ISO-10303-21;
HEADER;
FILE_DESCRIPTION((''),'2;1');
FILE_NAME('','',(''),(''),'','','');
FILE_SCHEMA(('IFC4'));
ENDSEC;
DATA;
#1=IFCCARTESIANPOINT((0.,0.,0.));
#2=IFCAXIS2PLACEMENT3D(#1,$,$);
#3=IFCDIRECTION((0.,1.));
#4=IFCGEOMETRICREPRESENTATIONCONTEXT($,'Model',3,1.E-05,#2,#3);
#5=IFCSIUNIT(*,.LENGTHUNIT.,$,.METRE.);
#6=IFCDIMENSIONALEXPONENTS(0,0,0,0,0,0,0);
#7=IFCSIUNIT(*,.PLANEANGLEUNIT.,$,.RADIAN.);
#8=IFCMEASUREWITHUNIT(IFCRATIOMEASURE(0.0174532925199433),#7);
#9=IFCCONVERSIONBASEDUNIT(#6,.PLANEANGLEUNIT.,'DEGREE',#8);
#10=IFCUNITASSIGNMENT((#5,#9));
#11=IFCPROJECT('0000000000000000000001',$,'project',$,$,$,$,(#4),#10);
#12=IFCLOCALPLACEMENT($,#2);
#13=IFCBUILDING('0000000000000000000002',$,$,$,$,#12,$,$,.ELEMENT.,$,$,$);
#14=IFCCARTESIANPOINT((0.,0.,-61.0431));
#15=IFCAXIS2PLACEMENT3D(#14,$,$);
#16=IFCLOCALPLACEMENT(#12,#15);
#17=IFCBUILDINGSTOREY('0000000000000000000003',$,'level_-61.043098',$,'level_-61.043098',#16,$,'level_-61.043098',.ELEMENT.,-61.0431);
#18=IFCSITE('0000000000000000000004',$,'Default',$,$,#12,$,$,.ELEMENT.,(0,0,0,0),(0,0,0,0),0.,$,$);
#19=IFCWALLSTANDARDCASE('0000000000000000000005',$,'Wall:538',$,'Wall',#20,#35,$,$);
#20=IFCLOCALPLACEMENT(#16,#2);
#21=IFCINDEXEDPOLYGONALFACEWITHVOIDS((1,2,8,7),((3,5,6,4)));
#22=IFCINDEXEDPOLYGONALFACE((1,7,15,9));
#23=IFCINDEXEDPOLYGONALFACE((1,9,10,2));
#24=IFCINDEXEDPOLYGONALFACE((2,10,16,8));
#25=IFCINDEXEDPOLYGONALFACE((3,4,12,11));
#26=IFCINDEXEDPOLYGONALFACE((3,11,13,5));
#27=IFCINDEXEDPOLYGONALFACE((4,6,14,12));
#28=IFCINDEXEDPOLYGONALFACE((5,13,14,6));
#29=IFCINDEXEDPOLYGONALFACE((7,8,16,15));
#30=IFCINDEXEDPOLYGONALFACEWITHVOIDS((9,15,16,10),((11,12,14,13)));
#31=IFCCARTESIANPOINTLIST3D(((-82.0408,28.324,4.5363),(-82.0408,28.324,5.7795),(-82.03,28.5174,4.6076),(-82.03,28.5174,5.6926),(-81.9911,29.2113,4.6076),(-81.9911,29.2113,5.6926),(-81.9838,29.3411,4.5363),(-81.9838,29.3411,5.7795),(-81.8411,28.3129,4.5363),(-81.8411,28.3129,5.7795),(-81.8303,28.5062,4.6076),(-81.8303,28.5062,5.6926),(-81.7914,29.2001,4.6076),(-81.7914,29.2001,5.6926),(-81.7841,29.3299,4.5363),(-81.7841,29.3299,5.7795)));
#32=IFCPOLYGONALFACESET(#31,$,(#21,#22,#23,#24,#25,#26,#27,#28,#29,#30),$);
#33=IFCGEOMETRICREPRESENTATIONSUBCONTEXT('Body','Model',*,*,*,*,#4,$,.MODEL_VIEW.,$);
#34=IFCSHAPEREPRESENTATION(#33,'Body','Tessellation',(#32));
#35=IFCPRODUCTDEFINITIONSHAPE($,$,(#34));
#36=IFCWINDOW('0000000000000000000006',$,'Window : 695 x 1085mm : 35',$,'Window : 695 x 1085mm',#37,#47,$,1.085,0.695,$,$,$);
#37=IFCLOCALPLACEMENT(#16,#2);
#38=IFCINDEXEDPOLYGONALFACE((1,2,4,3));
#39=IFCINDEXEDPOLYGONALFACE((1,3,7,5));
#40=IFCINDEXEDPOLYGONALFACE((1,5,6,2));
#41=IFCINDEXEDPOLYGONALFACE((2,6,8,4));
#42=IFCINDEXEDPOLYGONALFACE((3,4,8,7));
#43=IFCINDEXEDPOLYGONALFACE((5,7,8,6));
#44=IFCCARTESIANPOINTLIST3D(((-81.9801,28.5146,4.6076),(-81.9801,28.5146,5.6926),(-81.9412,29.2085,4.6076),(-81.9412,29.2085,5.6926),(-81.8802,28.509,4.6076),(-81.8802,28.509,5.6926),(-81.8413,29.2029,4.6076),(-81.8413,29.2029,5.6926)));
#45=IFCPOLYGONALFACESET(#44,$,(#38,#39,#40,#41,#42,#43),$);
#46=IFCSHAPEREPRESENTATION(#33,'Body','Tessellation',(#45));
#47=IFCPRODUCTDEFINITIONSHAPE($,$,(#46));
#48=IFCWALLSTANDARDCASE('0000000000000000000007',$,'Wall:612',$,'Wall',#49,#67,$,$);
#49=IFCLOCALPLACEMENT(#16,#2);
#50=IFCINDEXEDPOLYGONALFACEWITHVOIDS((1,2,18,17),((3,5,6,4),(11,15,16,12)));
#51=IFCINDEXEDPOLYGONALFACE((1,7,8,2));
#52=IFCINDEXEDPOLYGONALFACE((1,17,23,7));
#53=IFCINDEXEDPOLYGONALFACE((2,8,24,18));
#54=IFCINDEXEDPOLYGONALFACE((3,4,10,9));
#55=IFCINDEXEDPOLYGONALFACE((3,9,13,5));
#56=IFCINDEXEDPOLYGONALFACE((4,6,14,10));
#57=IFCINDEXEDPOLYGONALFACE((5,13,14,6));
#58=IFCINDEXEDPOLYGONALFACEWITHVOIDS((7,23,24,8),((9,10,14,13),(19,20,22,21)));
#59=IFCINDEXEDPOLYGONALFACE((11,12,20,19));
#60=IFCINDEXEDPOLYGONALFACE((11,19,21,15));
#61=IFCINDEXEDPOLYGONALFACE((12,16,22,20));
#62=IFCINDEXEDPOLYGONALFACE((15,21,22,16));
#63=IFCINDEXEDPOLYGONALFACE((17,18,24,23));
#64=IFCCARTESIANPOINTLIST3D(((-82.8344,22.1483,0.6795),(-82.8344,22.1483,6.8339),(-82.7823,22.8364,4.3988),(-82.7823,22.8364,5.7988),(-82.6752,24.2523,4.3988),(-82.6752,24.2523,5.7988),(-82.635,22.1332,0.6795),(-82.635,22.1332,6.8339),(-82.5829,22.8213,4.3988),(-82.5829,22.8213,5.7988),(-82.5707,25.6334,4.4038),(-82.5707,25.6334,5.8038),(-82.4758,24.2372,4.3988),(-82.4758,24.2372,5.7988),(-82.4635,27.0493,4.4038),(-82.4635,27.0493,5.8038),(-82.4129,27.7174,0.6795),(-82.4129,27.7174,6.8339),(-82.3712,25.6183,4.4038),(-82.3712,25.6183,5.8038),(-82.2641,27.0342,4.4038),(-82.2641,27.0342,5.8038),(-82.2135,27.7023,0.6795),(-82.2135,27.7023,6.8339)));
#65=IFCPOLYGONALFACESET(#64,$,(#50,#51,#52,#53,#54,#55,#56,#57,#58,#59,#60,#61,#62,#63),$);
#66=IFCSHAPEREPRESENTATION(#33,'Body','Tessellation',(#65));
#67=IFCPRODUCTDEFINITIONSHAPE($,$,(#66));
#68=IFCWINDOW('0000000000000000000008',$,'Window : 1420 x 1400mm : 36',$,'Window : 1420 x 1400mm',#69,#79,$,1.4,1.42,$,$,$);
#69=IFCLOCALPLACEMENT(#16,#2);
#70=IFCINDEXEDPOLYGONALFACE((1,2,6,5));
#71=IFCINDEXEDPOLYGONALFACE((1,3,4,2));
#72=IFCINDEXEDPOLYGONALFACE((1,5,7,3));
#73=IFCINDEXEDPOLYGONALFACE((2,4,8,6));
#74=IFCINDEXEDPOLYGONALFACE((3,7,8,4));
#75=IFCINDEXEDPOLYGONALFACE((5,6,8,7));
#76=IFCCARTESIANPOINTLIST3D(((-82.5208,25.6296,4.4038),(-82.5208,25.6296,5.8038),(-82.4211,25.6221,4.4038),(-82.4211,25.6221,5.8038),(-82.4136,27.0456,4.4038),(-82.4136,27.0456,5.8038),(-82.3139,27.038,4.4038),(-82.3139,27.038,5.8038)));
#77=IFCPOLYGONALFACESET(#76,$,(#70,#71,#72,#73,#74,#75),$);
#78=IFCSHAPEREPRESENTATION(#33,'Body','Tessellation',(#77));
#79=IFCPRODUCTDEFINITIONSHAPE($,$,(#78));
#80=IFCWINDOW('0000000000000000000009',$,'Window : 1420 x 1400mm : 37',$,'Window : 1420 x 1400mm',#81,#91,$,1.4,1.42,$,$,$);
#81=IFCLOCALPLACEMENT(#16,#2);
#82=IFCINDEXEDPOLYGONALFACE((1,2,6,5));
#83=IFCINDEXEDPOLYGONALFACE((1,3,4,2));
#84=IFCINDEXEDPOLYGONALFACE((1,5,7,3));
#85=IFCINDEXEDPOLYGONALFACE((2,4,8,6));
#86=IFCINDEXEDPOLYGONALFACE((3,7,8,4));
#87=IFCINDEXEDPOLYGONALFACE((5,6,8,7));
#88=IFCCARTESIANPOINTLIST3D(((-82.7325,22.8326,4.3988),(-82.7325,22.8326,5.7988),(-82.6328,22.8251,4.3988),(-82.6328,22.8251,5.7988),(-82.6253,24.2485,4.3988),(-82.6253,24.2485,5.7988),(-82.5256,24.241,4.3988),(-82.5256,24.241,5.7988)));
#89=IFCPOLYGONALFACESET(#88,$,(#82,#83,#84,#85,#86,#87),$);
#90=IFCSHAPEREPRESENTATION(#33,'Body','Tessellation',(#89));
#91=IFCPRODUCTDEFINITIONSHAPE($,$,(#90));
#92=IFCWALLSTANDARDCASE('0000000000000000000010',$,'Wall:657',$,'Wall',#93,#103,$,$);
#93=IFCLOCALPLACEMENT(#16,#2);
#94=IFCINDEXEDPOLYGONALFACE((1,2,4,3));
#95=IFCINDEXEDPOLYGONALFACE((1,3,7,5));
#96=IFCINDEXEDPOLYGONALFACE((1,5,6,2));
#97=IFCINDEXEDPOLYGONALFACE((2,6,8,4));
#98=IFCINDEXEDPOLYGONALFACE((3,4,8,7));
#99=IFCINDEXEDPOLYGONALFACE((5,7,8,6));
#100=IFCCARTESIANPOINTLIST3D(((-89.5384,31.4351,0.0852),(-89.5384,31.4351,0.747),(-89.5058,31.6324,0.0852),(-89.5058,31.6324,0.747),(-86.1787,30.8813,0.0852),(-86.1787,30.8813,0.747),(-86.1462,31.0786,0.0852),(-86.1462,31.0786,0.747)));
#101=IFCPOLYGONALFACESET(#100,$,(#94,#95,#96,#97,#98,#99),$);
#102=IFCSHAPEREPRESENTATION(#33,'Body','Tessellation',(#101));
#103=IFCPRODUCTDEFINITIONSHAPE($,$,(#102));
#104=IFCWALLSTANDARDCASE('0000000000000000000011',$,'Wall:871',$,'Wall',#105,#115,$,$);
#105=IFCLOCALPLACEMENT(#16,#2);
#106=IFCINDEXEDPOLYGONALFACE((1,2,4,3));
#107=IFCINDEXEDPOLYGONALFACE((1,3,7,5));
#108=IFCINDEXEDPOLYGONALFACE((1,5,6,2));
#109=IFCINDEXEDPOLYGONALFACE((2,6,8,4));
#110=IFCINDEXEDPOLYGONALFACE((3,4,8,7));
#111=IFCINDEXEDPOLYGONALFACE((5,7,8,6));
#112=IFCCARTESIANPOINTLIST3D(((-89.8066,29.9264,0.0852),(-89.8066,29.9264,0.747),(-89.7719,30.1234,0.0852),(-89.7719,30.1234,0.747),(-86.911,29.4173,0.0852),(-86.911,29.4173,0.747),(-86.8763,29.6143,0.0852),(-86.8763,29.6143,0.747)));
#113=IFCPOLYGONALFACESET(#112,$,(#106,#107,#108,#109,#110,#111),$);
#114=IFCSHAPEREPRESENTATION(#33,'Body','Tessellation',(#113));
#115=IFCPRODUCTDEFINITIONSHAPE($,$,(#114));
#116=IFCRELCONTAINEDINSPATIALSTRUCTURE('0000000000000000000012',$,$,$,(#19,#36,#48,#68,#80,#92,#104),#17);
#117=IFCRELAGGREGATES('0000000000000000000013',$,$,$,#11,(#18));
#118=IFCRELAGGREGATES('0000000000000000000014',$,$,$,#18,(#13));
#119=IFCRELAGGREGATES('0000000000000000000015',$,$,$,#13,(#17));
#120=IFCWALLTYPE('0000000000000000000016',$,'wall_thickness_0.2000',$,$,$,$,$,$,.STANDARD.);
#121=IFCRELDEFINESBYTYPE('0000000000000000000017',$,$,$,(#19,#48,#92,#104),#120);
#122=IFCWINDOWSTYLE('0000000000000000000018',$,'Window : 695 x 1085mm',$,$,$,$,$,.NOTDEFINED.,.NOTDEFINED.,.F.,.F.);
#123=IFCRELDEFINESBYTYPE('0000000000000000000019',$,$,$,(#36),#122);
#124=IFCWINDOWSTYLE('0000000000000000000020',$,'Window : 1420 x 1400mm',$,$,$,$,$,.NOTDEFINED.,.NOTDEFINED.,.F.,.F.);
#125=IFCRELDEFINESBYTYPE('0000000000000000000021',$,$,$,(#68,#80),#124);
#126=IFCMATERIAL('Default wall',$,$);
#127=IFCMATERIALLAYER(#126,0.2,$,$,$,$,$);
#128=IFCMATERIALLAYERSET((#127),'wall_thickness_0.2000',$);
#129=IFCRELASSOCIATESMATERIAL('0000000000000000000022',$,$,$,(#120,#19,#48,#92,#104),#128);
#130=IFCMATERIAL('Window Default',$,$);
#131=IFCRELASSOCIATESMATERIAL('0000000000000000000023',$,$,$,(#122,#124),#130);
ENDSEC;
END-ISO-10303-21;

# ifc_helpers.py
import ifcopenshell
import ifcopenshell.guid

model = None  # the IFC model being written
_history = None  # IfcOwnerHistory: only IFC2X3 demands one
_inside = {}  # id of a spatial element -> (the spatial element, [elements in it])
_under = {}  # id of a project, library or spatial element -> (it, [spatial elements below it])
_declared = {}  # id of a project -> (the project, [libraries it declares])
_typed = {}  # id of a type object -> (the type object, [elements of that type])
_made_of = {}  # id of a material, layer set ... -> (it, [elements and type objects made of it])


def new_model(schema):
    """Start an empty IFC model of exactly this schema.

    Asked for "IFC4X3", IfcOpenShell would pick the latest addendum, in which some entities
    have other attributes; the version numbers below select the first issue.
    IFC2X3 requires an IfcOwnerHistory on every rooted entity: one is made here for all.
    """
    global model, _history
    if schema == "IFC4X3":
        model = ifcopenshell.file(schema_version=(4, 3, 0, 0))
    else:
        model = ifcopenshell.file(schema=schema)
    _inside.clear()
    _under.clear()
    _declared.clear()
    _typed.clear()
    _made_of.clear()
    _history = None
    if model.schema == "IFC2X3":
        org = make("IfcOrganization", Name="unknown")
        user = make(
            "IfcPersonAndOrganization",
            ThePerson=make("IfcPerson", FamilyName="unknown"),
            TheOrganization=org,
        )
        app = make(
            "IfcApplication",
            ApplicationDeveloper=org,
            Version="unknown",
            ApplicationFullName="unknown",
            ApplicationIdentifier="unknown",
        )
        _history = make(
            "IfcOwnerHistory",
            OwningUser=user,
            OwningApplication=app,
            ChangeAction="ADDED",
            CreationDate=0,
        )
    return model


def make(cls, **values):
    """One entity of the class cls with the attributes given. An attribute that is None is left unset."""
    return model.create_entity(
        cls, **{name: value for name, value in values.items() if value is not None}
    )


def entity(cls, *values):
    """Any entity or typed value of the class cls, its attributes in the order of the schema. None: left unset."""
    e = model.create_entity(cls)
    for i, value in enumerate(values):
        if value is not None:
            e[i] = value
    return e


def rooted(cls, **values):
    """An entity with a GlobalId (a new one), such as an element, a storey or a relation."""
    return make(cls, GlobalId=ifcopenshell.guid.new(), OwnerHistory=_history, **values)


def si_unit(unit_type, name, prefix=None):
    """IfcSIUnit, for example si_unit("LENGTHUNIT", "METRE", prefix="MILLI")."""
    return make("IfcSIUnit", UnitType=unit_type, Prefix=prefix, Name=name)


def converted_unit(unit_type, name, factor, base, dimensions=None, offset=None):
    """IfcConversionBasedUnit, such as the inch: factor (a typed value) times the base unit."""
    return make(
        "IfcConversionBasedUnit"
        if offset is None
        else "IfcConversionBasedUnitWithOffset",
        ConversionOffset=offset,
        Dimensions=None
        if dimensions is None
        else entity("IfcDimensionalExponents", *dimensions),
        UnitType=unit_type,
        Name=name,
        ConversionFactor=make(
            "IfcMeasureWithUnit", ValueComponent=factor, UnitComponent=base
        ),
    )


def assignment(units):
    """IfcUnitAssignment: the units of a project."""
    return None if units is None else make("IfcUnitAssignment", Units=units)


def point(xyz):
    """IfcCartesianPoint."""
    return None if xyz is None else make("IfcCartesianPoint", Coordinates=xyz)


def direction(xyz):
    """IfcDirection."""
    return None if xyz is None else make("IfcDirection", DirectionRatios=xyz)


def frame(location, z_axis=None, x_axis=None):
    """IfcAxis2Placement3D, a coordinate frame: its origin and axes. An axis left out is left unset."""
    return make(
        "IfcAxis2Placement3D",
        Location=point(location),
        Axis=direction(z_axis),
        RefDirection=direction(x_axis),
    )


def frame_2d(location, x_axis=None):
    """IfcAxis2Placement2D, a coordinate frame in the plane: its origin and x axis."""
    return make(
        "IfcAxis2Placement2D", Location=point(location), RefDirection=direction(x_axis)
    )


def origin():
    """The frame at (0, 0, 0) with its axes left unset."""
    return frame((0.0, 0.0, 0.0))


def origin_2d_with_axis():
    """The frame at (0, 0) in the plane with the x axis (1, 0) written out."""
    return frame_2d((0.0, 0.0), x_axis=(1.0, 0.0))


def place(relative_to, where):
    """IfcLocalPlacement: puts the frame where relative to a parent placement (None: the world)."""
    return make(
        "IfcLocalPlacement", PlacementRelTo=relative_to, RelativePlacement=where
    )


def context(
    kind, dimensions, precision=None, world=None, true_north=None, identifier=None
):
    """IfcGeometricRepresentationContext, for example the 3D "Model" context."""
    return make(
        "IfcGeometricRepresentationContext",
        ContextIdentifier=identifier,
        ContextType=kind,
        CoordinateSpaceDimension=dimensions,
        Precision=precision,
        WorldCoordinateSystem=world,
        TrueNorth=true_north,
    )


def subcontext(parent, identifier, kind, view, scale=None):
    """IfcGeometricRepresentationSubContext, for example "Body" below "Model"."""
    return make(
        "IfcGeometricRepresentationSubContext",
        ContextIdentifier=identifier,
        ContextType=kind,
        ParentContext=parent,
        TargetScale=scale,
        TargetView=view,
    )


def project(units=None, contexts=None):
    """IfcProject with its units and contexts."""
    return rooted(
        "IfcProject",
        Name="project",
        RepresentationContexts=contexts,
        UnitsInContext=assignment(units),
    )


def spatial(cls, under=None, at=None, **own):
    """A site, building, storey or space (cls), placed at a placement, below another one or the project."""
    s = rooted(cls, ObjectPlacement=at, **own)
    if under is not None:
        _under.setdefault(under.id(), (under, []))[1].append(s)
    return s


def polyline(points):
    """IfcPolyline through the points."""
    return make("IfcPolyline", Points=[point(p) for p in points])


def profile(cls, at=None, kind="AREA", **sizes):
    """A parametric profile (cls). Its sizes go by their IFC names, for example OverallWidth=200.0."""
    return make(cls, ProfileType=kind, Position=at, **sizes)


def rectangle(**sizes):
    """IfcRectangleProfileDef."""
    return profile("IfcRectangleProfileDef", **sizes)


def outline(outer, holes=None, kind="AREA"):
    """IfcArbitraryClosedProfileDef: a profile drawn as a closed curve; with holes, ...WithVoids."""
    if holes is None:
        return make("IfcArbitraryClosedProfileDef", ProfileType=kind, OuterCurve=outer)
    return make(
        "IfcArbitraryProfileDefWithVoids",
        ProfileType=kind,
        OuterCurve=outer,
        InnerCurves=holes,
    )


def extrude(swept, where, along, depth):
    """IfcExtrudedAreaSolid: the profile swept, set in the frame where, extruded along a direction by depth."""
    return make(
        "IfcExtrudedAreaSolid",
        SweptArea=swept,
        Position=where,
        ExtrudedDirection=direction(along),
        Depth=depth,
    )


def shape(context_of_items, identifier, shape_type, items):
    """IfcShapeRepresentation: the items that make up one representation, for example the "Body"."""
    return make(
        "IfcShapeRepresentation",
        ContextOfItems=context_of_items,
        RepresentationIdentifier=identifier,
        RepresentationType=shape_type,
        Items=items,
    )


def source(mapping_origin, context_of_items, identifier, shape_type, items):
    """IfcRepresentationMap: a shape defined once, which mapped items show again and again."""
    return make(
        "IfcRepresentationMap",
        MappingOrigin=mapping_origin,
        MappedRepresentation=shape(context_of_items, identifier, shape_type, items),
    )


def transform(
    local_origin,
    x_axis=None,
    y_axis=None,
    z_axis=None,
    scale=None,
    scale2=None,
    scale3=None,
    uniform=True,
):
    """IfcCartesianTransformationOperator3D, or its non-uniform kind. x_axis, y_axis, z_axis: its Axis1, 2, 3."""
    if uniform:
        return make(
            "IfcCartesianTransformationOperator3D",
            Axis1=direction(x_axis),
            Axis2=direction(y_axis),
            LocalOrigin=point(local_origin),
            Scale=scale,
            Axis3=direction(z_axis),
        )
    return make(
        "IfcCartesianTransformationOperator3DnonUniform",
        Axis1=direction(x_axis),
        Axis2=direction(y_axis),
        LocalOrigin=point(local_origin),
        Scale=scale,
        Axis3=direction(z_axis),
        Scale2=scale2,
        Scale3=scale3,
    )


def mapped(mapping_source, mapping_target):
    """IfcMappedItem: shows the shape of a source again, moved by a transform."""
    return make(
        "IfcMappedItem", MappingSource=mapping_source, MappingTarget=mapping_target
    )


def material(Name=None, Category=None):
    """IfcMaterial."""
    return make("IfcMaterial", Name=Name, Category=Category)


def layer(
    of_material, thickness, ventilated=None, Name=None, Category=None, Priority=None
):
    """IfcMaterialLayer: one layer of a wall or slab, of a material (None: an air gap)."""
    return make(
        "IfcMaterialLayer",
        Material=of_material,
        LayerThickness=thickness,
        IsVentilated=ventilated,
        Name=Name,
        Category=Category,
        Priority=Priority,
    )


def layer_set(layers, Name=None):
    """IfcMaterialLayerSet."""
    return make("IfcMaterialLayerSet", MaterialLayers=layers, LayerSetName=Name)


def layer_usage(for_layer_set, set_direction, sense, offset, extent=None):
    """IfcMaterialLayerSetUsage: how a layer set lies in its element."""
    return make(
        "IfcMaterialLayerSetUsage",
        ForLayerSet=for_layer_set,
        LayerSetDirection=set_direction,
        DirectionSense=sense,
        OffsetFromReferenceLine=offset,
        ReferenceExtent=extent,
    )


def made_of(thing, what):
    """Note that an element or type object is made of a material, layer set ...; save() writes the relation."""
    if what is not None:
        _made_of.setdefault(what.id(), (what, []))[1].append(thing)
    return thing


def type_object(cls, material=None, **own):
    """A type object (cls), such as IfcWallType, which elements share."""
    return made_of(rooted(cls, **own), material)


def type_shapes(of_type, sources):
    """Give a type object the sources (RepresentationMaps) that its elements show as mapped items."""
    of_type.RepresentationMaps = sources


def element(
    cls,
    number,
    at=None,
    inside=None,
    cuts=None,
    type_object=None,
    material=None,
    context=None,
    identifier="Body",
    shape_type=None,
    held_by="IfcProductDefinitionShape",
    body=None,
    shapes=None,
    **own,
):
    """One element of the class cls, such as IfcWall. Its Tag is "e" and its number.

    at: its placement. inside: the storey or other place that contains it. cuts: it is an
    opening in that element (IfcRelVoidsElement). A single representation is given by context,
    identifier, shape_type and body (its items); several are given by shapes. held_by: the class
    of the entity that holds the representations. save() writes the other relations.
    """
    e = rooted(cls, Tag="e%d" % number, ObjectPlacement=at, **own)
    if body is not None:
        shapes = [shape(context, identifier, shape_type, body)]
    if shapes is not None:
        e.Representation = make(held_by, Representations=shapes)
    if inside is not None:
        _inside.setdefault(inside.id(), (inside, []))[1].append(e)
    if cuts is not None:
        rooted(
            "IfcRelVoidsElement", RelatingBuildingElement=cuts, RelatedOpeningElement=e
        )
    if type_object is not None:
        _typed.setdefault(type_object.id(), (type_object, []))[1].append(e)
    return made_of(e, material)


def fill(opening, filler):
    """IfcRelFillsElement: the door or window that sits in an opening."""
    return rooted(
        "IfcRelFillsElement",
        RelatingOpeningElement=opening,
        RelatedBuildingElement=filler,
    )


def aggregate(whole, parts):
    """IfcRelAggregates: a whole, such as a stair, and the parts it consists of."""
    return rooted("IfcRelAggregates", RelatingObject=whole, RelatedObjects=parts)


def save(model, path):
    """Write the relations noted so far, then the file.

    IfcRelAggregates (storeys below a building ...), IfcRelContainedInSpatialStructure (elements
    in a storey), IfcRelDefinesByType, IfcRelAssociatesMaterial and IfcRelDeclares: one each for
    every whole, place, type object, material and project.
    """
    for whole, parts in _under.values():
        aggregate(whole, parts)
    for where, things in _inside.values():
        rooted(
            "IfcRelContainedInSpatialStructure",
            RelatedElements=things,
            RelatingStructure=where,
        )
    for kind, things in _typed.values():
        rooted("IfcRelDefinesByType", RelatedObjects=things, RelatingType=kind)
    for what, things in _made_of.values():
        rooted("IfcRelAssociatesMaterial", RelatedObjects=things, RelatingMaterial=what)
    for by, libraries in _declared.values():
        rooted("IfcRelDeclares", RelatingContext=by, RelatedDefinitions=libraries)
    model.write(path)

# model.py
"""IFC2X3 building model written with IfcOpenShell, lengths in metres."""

from ifc_helpers import new_model, entity, si_unit, converted_unit, direction, frame, frame_2d, origin, origin_2d_with_axis, place, context, subcontext, project, spatial, polyline, rectangle, outline, extrude, source, transform, mapped, material, layer, layer_set, layer_usage, type_object, type_shapes, element, fill, save


model = new_model("IFC2X3")

# Units and contexts
model_context = context("Model", 3, precision=1e-05, world=origin(), true_north=direction((0.0, 1.0)))
body_context = subcontext(model_context, "Body", "Model", "MODEL_VIEW")
ifc_project = project(units=[si_unit("LENGTHUNIT", "METRE"), converted_unit("PLANEANGLEUNIT", "DEGREE", entity("IfcRatioMeasure", 0.0174532925199433), si_unit("PLANEANGLEUNIT", "RADIAN"), dimensions=[0, 0, 0, 0, 0, 0, 0])], contexts=[model_context])

# Site, building, storey
placement_1 = place(None, origin())
site = spatial("IfcSite", under=ifc_project, at=placement_1, Name="Default", CompositionType="ELEMENT", RefLatitude=(0, 0, 0, 0), RefLongitude=(0, 0, 0, 0), RefElevation=0.0)
building = spatial("IfcBuilding", under=site, at=placement_1, CompositionType="ELEMENT")
storey_placement = place(placement_1, frame((0.0, 0.0, -61.0431)))
storey = spatial("IfcBuildingStorey", under=building, at=storey_placement, Name="level_-61.043098", ObjectType="level_-61.043098", LongName="level_-61.043098", CompositionType="ELEMENT", Elevation=-61.0431)

# Wall, opening, window
ifc_material_1 = material(Name="Default wall")
ifc_layer = layer(ifc_material_1, 0.2)
ifc_layer_set = layer_set([ifc_layer], Name="wall_thickness_0.2000")
ifc_layer_usage = layer_usage(ifc_layer_set, "AXIS2", "POSITIVE", -0.1)
wall_type = type_object("IfcWallType", Name="wall_thickness_0.2000", PredefinedType="STANDARD", material=ifc_layer_set)
placement_2 = place(placement_1, frame((0.0, 0.0, -56.5068)))
wall_1_placement = place(placement_2, frame((-81.884, 29.3355, 0.0), z_axis=(0.0, 0.0, 1.0), x_axis=(-0.055986, -0.998432, 0.0)))
wall_1 = element("IfcWallStandardCase", 1, at=wall_1_placement, inside=storey, type_object=wall_type, material=ifc_layer_usage, Name="Wall:538", ObjectType="Wall", context=body_context, shape_type="SweptSolid", body=[
    extrude(outline(polyline([(1.0187, -0.1), (1.0187, 0.1), (0.0, 0.1), (0.0, -0.1), (1.0187, -0.1)])), origin(), (0.0, 0.0, 1.0), 1.2433),
])
opening_1_placement = place(wall_1_placement, frame((0.13, -0.1, 0.0714)))
opening_1 = element("IfcOpeningElement", 2, at=opening_1_placement, cuts=wall_1, ObjectType="Opening", context=body_context, shape_type="SweptSolid", body=[
    extrude(rectangle(XDim=0.695, YDim=1.085, at=frame_2d((0.5425, 0.3475), x_axis=(0.0, 1.0))), frame((0.0, 0.0, 0.0), z_axis=(0.0, 1.0, 0.0), x_axis=(0.0, 0.0, 1.0)), (0.0, 0.0, 1.0), 0.2),
])
ifc_material_2 = material(Name="Window Default")
window_style_1 = type_object("IfcWindowStyle", Name="Window : 695 x 1085mm", ConstructionType="NOTDEFINED", OperationType="NOTDEFINED", ParameterTakesPrecedence=False, Sizeable=False, material=ifc_material_2)
shared_shape_1 = source(origin(), body_context, "Body", "SweptSolid", [
    extrude(rectangle(XDim=0.1, YDim=0.695, at=origin_2d_with_axis()), frame((0.3475, 0.1, 0.0), z_axis=(0.0, 0.0, 1.0), x_axis=(0.0, 1.0, 0.0)), (0.0, 0.0, 1.0), 1.085),
])
type_shapes(window_style_1, [shared_shape_1])
window_1_placement = place(opening_1_placement, origin())
window_1 = element("IfcWindow", 3, at=window_1_placement, inside=storey, type_object=window_style_1, Name="Window : 695 x 1085mm : 35", ObjectType="Window : 695 x 1085mm", OverallHeight=1.085, OverallWidth=0.695, context=body_context, shape_type="MappedRepresentation", body=[
    mapped(shared_shape_1, transform((0.0, 0.0, 0.0), scale=1.0)),
])
fill(opening_1, window_1)

# Wall, openings, windows
placement_3 = place(placement_1, frame((0.0, 0.0, -60.3636)))
wall_2_placement = place(placement_3, frame((-82.3132, 27.7099, 0.0), z_axis=(0.0, 0.0, 1.0), x_axis=(-0.075466, -0.997148, 0.0)))
wall_2 = element("IfcWallStandardCase", 4, at=wall_2_placement, inside=storey, type_object=wall_type, material=ifc_layer_usage, Name="Wall:612", ObjectType="Wall", context=body_context, shape_type="SweptSolid", body=[
    extrude(outline(polyline([(5.585, -0.1), (5.585, 0.1), (0.0, 0.1), (0.0, -0.1), (5.585, -0.1)])), origin(), (0.0, 0.0, 1.0), 6.1544),
])
opening_2_placement = place(wall_2_placement, frame((0.67, -0.1, 3.7243)))
opening_2 = element("IfcOpeningElement", 5, at=opening_2_placement, cuts=wall_2, ObjectType="Opening", context=body_context, shape_type="SweptSolid", body=[
    extrude(rectangle(XDim=1.42, YDim=1.4, at=frame_2d((0.7, 0.71), x_axis=(0.0, 1.0))), frame((0.0, 0.0, 0.0), z_axis=(0.0, 1.0, 0.0), x_axis=(0.0, 0.0, 1.0)), (0.0, 0.0, 1.0), 0.2),
])
opening_3_placement = place(wall_2_placement, frame((3.475, -0.1, 3.7193)))
opening_3 = element("IfcOpeningElement", 6, at=opening_3_placement, cuts=wall_2, ObjectType="Opening", context=body_context, shape_type="SweptSolid", body=[
    extrude(rectangle(XDim=1.42, YDim=1.4, at=frame_2d((0.7, 0.71), x_axis=(0.0, 1.0))), frame((0.0, 0.0, 0.0), z_axis=(0.0, 1.0, 0.0), x_axis=(0.0, 0.0, 1.0)), (0.0, 0.0, 1.0), 0.2),
])
window_style_2 = type_object("IfcWindowStyle", Name="Window : 1420 x 1400mm", ConstructionType="NOTDEFINED", OperationType="NOTDEFINED", ParameterTakesPrecedence=False, Sizeable=False, material=ifc_material_2)
shared_shape_2 = source(origin(), body_context, "Body", "SweptSolid", [
    extrude(rectangle(XDim=0.1, YDim=1.42, at=origin_2d_with_axis()), frame((0.71, 0.1, 0.0), z_axis=(0.0, 0.0, 1.0), x_axis=(0.0, 1.0, 0.0)), (0.0, 0.0, 1.0), 1.4),
])
type_shapes(window_style_2, [shared_shape_2])
window_2_placement = place(opening_2_placement, origin())
window_2 = element("IfcWindow", 7, at=window_2_placement, inside=storey, type_object=window_style_2, Name="Window : 1420 x 1400mm : 36", ObjectType="Window : 1420 x 1400mm", OverallHeight=1.4, OverallWidth=1.42, context=body_context, shape_type="MappedRepresentation", body=[
    mapped(shared_shape_2, transform((0.0, 0.0, 0.0), scale=1.0)),
])
fill(opening_2, window_2)
window_3_placement = place(opening_3_placement, origin())
window_3 = element("IfcWindow", 8, at=window_3_placement, inside=storey, type_object=window_style_2, Name="Window : 1420 x 1400mm : 37", ObjectType="Window : 1420 x 1400mm", OverallHeight=1.4, OverallWidth=1.42, context=body_context, shape_type="MappedRepresentation", body=[
    mapped(shared_shape_2, transform((0.0, 0.0, 0.0), scale=1.0)),
])
fill(opening_3, window_3)

# Walls
placement_4 = place(placement_1, frame((0.0, 0.0, -60.9579)))
wall_3_placement = place(placement_4, frame((-89.5221, 31.5338, 0.0), z_axis=(0.0, 0.0, 1.0), x_axis=(0.986685, -0.162644, 0.0)))
element("IfcWallStandardCase", 9, at=wall_3_placement, inside=storey, type_object=wall_type, material=ifc_layer_usage, Name="Wall:657", ObjectType="Wall", context=body_context, shape_type="SweptSolid", body=[
    extrude(outline(polyline([(3.405, -0.1), (3.405, 0.1), (0.0, 0.1), (0.0, -0.1), (3.405, -0.1)])), origin(), (0.0, 0.0, 1.0), 0.6618),
])
placement_5 = place(placement_1, frame((0.0, 0.0, -60.9579)))
wall_4_placement = place(placement_5, frame((-89.7892, 30.0249, 0.0), z_axis=(0.0, 0.0, 1.0), x_axis=(0.984895, -0.173155, 0.0)))
element("IfcWallStandardCase", 10, at=wall_4_placement, inside=storey, type_object=wall_type, material=ifc_layer_usage, Name="Wall:871", ObjectType="Wall", context=body_context, shape_type="SweptSolid", body=[
    extrude(outline(polyline([(2.94, -0.1), (2.94, 0.1), (0.0, 0.1), (0.0, -0.1), (2.94, -0.1)])), origin(), (0.0, 0.0, 1.0), 0.6618),
])

save(model, "model.ifc")
